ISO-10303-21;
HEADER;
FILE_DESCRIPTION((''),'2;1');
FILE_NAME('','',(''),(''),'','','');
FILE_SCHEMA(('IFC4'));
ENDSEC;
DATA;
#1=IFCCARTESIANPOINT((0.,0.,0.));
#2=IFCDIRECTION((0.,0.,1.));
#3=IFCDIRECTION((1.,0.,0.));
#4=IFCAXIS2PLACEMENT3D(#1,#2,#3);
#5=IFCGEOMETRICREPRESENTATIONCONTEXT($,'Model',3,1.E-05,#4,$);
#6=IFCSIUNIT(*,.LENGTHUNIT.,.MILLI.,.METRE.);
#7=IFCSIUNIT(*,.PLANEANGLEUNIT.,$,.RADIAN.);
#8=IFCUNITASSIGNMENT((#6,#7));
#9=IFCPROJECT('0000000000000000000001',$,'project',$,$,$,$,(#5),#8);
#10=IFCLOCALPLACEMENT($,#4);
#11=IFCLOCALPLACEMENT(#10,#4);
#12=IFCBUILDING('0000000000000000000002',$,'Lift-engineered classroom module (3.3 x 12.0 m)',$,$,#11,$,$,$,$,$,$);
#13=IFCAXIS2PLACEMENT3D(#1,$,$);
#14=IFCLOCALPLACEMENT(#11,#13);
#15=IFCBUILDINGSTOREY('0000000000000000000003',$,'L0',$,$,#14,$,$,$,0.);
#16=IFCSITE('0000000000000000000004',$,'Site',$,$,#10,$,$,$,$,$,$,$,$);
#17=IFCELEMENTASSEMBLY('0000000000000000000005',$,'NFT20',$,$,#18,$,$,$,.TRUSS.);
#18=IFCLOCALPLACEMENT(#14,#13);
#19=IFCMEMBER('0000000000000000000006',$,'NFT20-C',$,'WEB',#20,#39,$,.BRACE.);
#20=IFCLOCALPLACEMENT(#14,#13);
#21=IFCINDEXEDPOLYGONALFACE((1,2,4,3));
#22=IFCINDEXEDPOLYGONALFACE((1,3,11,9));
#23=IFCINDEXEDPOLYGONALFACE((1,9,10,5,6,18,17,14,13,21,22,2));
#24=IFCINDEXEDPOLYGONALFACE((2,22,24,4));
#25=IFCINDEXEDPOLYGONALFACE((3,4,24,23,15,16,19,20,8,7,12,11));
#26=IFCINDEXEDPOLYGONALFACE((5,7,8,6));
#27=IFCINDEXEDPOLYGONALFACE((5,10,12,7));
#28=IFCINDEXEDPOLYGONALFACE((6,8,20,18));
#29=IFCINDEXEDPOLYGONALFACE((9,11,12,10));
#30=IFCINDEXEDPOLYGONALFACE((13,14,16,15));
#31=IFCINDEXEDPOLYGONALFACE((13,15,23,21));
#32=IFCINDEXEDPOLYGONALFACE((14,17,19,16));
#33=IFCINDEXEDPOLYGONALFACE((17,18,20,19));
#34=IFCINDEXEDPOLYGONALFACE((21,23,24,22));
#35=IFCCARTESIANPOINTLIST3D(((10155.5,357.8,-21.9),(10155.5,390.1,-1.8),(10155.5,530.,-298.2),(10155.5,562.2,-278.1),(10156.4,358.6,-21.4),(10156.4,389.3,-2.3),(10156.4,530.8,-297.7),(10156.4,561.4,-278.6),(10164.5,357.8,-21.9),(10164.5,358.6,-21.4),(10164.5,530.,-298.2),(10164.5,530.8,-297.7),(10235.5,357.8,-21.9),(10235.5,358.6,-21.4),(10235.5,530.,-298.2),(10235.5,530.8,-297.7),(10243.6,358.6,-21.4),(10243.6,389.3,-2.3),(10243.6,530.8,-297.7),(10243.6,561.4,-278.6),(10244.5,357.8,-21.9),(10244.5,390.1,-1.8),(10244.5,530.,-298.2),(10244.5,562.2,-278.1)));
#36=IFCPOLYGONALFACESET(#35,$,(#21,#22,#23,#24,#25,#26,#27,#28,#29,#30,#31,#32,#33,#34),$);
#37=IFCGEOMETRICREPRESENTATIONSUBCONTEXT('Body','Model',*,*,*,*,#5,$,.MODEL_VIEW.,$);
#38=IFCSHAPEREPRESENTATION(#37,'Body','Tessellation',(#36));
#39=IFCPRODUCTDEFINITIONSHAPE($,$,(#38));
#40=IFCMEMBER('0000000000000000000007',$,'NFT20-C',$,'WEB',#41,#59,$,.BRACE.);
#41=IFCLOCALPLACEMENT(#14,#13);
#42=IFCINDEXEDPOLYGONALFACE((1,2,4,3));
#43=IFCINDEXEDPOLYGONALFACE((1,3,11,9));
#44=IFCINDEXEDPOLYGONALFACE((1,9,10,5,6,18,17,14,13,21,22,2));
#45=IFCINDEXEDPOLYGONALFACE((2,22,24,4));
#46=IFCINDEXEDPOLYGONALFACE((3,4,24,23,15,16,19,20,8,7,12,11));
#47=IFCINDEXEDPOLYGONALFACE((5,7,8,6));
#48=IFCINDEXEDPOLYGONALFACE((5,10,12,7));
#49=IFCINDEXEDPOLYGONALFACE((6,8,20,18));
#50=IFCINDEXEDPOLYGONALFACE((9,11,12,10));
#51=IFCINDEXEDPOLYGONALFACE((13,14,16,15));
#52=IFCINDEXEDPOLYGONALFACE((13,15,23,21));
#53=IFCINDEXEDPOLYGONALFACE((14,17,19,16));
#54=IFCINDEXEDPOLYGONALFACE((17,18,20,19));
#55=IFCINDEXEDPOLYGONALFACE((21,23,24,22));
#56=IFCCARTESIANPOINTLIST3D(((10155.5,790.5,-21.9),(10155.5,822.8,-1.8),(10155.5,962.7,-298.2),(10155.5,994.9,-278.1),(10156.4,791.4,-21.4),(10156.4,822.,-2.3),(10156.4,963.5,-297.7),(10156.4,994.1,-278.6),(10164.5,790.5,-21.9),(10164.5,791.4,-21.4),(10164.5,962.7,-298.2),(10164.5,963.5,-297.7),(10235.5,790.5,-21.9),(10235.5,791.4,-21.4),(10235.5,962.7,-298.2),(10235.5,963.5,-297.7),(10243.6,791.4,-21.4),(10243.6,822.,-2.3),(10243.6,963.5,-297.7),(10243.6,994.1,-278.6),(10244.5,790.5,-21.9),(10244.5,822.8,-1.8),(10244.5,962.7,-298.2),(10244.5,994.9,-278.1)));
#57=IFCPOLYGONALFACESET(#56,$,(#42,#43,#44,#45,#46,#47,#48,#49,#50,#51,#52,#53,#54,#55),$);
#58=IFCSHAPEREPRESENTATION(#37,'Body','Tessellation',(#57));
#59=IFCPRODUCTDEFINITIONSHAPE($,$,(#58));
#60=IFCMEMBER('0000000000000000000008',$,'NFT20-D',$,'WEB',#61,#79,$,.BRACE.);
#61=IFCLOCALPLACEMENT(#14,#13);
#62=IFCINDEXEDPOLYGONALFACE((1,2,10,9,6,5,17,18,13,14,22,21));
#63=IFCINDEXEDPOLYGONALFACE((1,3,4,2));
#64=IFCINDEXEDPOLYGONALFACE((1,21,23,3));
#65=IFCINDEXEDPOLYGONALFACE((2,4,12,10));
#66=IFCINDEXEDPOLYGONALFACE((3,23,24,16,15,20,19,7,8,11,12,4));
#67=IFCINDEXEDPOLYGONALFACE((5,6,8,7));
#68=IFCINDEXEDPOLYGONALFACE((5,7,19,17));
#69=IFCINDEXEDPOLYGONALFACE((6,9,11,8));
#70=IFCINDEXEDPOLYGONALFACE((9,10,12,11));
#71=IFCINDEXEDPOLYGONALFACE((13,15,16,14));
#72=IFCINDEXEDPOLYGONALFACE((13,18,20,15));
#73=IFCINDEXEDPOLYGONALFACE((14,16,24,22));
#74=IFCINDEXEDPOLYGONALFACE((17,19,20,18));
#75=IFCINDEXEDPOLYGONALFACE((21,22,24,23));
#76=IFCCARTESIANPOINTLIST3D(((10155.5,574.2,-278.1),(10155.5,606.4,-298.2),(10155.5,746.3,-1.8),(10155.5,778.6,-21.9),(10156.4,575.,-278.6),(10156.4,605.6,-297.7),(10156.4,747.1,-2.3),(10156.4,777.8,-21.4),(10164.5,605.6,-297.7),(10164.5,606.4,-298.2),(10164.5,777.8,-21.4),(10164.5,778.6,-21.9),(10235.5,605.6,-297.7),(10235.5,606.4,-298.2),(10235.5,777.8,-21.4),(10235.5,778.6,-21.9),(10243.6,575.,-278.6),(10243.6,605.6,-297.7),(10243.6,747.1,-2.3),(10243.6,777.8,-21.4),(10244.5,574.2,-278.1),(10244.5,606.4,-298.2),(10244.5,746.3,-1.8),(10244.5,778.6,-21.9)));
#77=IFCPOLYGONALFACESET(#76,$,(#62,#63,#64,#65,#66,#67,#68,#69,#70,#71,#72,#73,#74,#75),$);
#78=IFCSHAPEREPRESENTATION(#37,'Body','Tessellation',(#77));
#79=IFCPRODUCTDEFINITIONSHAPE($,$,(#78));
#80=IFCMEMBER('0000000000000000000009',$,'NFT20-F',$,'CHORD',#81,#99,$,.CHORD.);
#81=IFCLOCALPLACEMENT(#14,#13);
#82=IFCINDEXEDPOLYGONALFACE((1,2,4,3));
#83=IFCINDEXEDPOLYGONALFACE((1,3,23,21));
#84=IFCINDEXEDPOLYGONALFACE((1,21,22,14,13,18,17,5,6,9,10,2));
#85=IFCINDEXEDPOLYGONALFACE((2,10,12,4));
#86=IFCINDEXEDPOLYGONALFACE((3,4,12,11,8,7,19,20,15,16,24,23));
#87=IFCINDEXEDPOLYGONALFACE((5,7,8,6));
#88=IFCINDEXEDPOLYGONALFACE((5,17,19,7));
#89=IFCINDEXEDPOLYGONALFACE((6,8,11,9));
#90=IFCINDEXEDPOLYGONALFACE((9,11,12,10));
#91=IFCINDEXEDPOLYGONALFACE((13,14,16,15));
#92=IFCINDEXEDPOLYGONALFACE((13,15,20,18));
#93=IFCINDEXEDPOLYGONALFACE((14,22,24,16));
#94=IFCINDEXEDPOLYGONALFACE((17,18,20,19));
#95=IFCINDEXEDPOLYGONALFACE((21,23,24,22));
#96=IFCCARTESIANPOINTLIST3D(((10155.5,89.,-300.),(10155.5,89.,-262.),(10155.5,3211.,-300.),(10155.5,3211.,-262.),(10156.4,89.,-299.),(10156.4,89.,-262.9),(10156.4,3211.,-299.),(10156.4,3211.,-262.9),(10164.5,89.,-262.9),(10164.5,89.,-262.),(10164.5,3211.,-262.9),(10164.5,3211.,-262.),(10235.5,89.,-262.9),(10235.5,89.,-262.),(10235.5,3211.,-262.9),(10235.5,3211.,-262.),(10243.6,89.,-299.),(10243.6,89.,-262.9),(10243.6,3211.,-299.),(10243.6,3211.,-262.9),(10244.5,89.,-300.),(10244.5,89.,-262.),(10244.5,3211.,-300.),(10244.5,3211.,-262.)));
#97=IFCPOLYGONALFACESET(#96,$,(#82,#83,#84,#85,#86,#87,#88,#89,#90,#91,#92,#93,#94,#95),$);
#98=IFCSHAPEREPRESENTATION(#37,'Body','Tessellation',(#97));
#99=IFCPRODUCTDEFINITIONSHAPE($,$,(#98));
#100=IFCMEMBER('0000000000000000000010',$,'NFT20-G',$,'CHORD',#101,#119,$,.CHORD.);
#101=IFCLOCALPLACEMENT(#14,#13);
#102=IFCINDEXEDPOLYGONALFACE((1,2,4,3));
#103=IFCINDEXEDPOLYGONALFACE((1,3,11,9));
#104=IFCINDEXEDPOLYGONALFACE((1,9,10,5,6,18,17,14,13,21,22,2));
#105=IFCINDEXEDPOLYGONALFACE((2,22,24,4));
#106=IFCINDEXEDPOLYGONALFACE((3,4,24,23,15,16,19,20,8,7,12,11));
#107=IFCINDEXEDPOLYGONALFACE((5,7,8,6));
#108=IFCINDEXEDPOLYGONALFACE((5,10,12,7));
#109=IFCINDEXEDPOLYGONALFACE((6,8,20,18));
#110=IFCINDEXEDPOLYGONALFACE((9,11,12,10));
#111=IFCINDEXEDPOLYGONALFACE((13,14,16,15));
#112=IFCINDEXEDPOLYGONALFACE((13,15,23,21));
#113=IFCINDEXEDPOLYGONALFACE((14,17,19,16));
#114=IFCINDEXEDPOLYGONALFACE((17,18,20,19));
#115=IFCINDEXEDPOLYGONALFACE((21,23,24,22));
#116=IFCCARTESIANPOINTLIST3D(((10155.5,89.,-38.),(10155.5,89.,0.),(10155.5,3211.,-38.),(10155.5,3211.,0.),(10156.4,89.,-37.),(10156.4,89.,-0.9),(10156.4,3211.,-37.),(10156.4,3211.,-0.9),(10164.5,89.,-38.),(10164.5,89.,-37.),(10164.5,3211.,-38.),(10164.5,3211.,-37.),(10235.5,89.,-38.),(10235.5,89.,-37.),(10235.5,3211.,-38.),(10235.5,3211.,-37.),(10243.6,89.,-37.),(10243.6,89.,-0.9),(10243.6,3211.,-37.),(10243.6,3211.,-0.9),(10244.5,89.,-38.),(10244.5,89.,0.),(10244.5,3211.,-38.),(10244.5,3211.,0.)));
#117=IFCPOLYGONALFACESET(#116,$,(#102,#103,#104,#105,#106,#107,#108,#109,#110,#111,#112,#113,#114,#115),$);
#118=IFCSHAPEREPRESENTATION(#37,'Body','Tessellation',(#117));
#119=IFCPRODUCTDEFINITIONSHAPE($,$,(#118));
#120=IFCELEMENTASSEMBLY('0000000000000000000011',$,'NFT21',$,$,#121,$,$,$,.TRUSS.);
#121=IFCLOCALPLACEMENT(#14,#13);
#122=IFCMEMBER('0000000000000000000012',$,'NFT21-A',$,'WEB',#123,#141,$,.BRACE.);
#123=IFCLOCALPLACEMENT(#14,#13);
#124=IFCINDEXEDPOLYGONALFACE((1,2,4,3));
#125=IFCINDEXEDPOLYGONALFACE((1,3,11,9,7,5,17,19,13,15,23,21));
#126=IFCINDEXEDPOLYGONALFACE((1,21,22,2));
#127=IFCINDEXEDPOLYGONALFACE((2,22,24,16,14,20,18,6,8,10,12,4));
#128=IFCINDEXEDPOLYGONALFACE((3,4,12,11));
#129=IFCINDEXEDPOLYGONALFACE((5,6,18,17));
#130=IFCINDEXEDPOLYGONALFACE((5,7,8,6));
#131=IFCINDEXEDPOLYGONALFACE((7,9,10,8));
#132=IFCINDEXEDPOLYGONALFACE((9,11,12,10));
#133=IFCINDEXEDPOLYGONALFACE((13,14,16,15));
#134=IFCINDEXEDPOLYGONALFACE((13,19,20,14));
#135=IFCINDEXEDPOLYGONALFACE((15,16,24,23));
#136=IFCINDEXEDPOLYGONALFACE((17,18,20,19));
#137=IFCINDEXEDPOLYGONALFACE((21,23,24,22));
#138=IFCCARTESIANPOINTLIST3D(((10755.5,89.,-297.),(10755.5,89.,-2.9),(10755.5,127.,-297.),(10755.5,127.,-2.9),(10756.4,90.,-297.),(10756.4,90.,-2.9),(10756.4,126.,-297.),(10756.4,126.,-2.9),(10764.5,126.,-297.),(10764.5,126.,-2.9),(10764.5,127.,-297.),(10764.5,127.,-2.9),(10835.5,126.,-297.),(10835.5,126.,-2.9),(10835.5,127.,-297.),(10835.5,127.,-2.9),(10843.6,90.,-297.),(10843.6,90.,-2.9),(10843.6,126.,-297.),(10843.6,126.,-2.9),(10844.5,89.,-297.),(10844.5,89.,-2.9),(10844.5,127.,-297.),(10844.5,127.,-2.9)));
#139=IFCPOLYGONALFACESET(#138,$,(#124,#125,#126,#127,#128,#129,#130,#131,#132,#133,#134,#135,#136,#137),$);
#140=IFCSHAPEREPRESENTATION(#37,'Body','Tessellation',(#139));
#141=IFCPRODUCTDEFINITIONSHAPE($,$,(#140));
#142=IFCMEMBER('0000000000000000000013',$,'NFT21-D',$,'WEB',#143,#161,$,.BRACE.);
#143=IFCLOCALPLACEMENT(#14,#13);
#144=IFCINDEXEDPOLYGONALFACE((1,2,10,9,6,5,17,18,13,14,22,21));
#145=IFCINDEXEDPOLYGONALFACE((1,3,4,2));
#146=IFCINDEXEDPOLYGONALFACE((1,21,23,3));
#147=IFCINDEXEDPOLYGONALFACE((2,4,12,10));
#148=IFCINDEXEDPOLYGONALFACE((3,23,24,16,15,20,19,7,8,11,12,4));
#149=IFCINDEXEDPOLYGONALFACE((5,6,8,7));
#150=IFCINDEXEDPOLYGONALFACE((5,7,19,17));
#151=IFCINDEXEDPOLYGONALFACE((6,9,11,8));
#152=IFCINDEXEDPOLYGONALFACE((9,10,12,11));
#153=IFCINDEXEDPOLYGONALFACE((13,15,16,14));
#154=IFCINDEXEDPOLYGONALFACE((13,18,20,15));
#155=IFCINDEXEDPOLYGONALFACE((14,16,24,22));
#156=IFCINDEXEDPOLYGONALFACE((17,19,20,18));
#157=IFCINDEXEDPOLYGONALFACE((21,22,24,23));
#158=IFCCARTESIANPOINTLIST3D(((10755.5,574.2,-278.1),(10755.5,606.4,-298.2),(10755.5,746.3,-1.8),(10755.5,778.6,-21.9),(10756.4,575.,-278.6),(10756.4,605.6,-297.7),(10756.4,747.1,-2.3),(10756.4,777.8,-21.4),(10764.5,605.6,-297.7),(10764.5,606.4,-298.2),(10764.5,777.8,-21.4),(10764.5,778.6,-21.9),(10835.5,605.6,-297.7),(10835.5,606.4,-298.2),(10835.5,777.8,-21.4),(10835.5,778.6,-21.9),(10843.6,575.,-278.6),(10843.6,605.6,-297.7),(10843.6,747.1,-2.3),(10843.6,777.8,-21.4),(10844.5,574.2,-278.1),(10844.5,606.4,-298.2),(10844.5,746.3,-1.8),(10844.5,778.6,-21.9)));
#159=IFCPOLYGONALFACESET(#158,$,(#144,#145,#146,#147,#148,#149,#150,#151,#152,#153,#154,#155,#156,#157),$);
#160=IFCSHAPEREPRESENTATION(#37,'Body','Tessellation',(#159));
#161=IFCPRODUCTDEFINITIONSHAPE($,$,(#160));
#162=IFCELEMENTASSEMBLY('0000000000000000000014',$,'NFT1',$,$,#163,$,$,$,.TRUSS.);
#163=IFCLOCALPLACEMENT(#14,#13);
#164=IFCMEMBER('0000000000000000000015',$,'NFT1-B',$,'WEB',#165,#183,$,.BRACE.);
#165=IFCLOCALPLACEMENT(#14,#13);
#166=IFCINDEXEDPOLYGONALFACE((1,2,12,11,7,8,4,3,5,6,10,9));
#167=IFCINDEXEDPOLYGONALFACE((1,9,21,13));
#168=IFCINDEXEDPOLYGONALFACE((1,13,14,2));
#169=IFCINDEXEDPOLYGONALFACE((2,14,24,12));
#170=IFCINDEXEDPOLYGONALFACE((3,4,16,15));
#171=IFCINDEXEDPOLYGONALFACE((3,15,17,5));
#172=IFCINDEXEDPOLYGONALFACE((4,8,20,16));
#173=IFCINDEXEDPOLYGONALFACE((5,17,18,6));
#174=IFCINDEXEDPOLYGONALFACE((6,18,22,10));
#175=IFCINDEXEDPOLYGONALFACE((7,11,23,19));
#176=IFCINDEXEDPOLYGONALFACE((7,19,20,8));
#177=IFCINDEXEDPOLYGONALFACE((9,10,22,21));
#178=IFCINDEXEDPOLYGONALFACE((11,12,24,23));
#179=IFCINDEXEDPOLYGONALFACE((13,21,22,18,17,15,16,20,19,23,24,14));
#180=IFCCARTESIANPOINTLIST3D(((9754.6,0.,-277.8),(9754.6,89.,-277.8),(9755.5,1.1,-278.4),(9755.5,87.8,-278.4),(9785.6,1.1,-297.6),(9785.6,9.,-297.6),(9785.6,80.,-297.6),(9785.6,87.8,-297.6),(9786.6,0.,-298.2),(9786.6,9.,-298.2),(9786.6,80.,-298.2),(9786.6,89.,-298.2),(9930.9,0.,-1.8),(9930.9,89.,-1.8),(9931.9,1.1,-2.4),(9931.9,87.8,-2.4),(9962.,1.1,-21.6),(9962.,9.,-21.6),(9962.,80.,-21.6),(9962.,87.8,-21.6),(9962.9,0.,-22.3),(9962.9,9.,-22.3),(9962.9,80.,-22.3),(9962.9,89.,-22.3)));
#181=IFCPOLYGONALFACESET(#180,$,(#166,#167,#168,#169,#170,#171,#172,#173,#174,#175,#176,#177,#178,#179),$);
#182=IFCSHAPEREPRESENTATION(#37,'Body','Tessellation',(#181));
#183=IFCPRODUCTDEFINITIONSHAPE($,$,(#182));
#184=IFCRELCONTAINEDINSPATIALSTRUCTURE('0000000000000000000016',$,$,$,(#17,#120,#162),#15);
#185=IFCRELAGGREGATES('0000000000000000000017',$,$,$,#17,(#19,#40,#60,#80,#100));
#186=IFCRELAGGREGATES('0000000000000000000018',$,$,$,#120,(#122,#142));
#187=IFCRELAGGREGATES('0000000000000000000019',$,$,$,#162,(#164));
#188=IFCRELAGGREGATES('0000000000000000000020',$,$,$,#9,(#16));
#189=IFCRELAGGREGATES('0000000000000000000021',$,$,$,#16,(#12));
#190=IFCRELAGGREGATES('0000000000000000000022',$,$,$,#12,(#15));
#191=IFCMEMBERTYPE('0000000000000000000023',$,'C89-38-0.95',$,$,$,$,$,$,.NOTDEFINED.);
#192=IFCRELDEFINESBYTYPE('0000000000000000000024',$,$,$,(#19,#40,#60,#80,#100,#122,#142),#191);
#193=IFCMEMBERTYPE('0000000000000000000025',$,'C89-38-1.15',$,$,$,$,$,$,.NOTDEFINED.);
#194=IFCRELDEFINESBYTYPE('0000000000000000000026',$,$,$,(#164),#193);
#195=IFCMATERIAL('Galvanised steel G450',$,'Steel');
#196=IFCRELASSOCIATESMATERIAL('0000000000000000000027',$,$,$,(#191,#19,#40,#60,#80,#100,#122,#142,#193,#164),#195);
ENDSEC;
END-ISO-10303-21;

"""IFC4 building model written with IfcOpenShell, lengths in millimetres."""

from ifc_helpers import new_model, si_unit, frame, origin, origin_with_axes, origin_2d, place, context, subcontext, project, spatial, c_section, extrude, material, material_profile, profile_set, profile_usage, type_object, element, aggregate, save


model = new_model("IFC4")

# Units and contexts
model_context = context("Model", 3, precision=1e-05, world=origin_with_axes())
body_context = subcontext(model_context, "Body", "Model", "MODEL_VIEW")
ifc_project = project(units=[si_unit("LENGTHUNIT", "METRE", prefix="MILLI"), si_unit("PLANEANGLEUNIT", "RADIAN")], contexts=[model_context])

# Site, building, storey
site_placement = place(None, origin_with_axes())
site = spatial("IfcSite", under=ifc_project, at=site_placement, Name="Site")
building_placement = place(site_placement, origin_with_axes())
building = spatial("IfcBuilding", under=site, at=building_placement, Name="Lift-engineered classroom module (3.3 x 12.0 m)")
storey_placement = place(building_placement, origin())
storey = spatial("IfcBuildingStorey", under=building, at=storey_placement, Name="L0", Elevation=0.0)

# Element assemblies, members
ifc_material = material(Name="Galvanised steel G450", Category="Steel")
ifc_material_profile_1 = material_profile(ifc_material, c_section(Depth=89.0, Width=38.0, WallThickness=0.9, Girth=9.0, at=origin_2d()), Name="C89-38-0.95")
ifc_profile_set_1 = profile_set([ifc_material_profile_1], Name="C89-38-0.95")
ifc_profile_usage_1 = profile_usage(ifc_profile_set_1)
member_type_1 = type_object("IfcMemberType", Name="C89-38-0.95", PredefinedType="NOTDEFINED", material=ifc_profile_set_1)
assembly_1_placement = place(storey_placement, frame((10200.0, 89.0, -300.0)))
assembly_1 = element("IfcElementAssembly", 1, at=assembly_1_placement, inside=storey, Name="NFT20", PredefinedType="TRUSS")
member_1_placement = place(assembly_1_placement, frame((0.0, 457.1, 11.8), z_axis=(0.0, -0.528797, 0.848748), x_axis=(0.0, -0.848748, -0.528797)))
member_1 = element("IfcMember", 2, at=member_1_placement, type_object=member_type_1, material=ifc_profile_usage_1, Name="NFT20-C", ObjectType="WEB", PredefinedType="BRACE", context=body_context, shape_type="SweptSolid", body=[
    extrude(c_section(Depth=89.0, Width=38.0, WallThickness=0.9, Girth=9.0, at=origin_2d()), origin(), (0.0, 0.0, 1.0), 325.6),
])
member_2_placement = place(assembly_1_placement, frame((0.0, 889.8, 11.8), z_axis=(0.0, -0.528797, 0.848748), x_axis=(0.0, -0.848748, -0.528797)))
member_2 = element("IfcMember", 3, at=member_2_placement, type_object=member_type_1, material=ifc_profile_usage_1, Name="NFT20-C", ObjectType="WEB", PredefinedType="BRACE", context=body_context, shape_type="SweptSolid", body=[
    extrude(c_section(Depth=89.0, Width=38.0, WallThickness=0.9, Girth=9.0, at=origin_2d()), origin(), (0.0, 0.0, 1.0), 325.6),
])
member_3_placement = place(assembly_1_placement, frame((0.0, 501.3, 11.8), z_axis=(0.0, 0.528775, 0.848762), x_axis=(0.0, 0.848762, -0.528775)))
member_3 = element("IfcMember", 4, at=member_3_placement, type_object=member_type_1, material=ifc_profile_usage_1, Name="NFT20-D", ObjectType="WEB", PredefinedType="BRACE", context=body_context, shape_type="SweptSolid", body=[
    extrude(c_section(Depth=89.0, Width=38.0, WallThickness=0.9, Girth=9.0, at=origin_2d()), origin(), (0.0, 0.0, 1.0), 325.6),
])
member_4_placement = place(assembly_1_placement, frame((0.0, 0.0, 19.0), z_axis=(0.0, 1.0, 0.0), x_axis=(0.0, 0.0, 1.0)))
member_4 = element("IfcMember", 5, at=member_4_placement, type_object=member_type_1, material=ifc_profile_usage_1, Name="NFT20-F", ObjectType="CHORD", PredefinedType="CHORD", context=body_context, shape_type="SweptSolid", body=[
    extrude(c_section(Depth=89.0, Width=38.0, WallThickness=0.9, Girth=9.0, at=origin_2d()), origin(), (0.0, 0.0, 1.0), 3122.0),
])
member_5_placement = place(assembly_1_placement, frame((0.0, 0.0, 281.0), z_axis=(0.0, 1.0, 0.0), x_axis=(0.0, 0.0, -1.0)))
member_5 = element("IfcMember", 6, at=member_5_placement, type_object=member_type_1, material=ifc_profile_usage_1, Name="NFT20-G", ObjectType="CHORD", PredefinedType="CHORD", context=body_context, shape_type="SweptSolid", body=[
    extrude(c_section(Depth=89.0, Width=38.0, WallThickness=0.9, Girth=9.0, at=origin_2d()), origin(), (0.0, 0.0, 1.0), 3122.0),
])
aggregate(assembly_1, [member_1, member_2, member_3, member_4, member_5])
assembly_2_placement = place(storey_placement, frame((10800.0, 89.0, -300.0)))
assembly_2 = element("IfcElementAssembly", 7, at=assembly_2_placement, inside=storey, Name="NFT21", PredefinedType="TRUSS")
member_6_placement = place(assembly_2_placement, frame((0.0, 19.0, 2.9), z_axis=(0.0, 0.0, 1.0), x_axis=(0.0, 1.0, 0.0)))
member_6 = element("IfcMember", 8, at=member_6_placement, type_object=member_type_1, material=ifc_profile_usage_1, Name="NFT21-A", ObjectType="WEB", PredefinedType="BRACE", context=body_context, shape_type="SweptSolid", body=[
    extrude(c_section(Depth=89.0, Width=38.0, WallThickness=0.9, Girth=9.0, at=origin_2d()), origin(), (0.0, 0.0, 1.0), 294.1),
])
member_7_placement = place(assembly_2_placement, frame((0.0, 501.3, 11.8), z_axis=(0.0, 0.528775, 0.848762), x_axis=(0.0, 0.848762, -0.528775)))
member_7 = element("IfcMember", 9, at=member_7_placement, type_object=member_type_1, material=ifc_profile_usage_1, Name="NFT21-D", ObjectType="WEB", PredefinedType="BRACE", context=body_context, shape_type="SweptSolid", body=[
    extrude(c_section(Depth=89.0, Width=38.0, WallThickness=0.9, Girth=9.0, at=origin_2d()), origin(), (0.0, 0.0, 1.0), 325.6),
])
aggregate(assembly_2, [member_6, member_7])
assembly_3_placement = place(storey_placement, frame((0.0, 44.5, -300.0)))
assembly_3 = element("IfcElementAssembly", 10, at=assembly_3_placement, inside=storey, Name="NFT1", PredefinedType="TRUSS")
ifc_material_profile_2 = material_profile(ifc_material, c_section(Depth=89.0, Width=38.0, WallThickness=1.1, Girth=9.0, at=origin_2d()), Name="C89-38-1.15")
ifc_profile_set_2 = profile_set([ifc_material_profile_2], Name="C89-38-1.15")
ifc_profile_usage_2 = profile_usage(ifc_profile_set_2)
member_type_2 = type_object("IfcMemberType", Name="C89-38-1.15", PredefinedType="NOTDEFINED", material=ifc_profile_set_2)
member_8_placement = place(assembly_3_placement, frame((9770.6, 0.0, 12.0), z_axis=(0.538459, 0.0, 0.842652), x_axis=(0.842652, 0.0, -0.538459)))
member_8 = element("IfcMember", 11, at=member_8_placement, type_object=member_type_2, material=ifc_profile_usage_2, Name="NFT1-B", ObjectType="WEB", PredefinedType="BRACE", context=body_context, shape_type="SweptSolid", body=[
    extrude(c_section(Depth=89.0, Width=38.0, WallThickness=1.1, Girth=9.0, at=origin_2d()), origin(), (0.0, 0.0, 1.0), 327.5),
])
aggregate(assembly_3, [member_8])

save(model, "model.ifc")
